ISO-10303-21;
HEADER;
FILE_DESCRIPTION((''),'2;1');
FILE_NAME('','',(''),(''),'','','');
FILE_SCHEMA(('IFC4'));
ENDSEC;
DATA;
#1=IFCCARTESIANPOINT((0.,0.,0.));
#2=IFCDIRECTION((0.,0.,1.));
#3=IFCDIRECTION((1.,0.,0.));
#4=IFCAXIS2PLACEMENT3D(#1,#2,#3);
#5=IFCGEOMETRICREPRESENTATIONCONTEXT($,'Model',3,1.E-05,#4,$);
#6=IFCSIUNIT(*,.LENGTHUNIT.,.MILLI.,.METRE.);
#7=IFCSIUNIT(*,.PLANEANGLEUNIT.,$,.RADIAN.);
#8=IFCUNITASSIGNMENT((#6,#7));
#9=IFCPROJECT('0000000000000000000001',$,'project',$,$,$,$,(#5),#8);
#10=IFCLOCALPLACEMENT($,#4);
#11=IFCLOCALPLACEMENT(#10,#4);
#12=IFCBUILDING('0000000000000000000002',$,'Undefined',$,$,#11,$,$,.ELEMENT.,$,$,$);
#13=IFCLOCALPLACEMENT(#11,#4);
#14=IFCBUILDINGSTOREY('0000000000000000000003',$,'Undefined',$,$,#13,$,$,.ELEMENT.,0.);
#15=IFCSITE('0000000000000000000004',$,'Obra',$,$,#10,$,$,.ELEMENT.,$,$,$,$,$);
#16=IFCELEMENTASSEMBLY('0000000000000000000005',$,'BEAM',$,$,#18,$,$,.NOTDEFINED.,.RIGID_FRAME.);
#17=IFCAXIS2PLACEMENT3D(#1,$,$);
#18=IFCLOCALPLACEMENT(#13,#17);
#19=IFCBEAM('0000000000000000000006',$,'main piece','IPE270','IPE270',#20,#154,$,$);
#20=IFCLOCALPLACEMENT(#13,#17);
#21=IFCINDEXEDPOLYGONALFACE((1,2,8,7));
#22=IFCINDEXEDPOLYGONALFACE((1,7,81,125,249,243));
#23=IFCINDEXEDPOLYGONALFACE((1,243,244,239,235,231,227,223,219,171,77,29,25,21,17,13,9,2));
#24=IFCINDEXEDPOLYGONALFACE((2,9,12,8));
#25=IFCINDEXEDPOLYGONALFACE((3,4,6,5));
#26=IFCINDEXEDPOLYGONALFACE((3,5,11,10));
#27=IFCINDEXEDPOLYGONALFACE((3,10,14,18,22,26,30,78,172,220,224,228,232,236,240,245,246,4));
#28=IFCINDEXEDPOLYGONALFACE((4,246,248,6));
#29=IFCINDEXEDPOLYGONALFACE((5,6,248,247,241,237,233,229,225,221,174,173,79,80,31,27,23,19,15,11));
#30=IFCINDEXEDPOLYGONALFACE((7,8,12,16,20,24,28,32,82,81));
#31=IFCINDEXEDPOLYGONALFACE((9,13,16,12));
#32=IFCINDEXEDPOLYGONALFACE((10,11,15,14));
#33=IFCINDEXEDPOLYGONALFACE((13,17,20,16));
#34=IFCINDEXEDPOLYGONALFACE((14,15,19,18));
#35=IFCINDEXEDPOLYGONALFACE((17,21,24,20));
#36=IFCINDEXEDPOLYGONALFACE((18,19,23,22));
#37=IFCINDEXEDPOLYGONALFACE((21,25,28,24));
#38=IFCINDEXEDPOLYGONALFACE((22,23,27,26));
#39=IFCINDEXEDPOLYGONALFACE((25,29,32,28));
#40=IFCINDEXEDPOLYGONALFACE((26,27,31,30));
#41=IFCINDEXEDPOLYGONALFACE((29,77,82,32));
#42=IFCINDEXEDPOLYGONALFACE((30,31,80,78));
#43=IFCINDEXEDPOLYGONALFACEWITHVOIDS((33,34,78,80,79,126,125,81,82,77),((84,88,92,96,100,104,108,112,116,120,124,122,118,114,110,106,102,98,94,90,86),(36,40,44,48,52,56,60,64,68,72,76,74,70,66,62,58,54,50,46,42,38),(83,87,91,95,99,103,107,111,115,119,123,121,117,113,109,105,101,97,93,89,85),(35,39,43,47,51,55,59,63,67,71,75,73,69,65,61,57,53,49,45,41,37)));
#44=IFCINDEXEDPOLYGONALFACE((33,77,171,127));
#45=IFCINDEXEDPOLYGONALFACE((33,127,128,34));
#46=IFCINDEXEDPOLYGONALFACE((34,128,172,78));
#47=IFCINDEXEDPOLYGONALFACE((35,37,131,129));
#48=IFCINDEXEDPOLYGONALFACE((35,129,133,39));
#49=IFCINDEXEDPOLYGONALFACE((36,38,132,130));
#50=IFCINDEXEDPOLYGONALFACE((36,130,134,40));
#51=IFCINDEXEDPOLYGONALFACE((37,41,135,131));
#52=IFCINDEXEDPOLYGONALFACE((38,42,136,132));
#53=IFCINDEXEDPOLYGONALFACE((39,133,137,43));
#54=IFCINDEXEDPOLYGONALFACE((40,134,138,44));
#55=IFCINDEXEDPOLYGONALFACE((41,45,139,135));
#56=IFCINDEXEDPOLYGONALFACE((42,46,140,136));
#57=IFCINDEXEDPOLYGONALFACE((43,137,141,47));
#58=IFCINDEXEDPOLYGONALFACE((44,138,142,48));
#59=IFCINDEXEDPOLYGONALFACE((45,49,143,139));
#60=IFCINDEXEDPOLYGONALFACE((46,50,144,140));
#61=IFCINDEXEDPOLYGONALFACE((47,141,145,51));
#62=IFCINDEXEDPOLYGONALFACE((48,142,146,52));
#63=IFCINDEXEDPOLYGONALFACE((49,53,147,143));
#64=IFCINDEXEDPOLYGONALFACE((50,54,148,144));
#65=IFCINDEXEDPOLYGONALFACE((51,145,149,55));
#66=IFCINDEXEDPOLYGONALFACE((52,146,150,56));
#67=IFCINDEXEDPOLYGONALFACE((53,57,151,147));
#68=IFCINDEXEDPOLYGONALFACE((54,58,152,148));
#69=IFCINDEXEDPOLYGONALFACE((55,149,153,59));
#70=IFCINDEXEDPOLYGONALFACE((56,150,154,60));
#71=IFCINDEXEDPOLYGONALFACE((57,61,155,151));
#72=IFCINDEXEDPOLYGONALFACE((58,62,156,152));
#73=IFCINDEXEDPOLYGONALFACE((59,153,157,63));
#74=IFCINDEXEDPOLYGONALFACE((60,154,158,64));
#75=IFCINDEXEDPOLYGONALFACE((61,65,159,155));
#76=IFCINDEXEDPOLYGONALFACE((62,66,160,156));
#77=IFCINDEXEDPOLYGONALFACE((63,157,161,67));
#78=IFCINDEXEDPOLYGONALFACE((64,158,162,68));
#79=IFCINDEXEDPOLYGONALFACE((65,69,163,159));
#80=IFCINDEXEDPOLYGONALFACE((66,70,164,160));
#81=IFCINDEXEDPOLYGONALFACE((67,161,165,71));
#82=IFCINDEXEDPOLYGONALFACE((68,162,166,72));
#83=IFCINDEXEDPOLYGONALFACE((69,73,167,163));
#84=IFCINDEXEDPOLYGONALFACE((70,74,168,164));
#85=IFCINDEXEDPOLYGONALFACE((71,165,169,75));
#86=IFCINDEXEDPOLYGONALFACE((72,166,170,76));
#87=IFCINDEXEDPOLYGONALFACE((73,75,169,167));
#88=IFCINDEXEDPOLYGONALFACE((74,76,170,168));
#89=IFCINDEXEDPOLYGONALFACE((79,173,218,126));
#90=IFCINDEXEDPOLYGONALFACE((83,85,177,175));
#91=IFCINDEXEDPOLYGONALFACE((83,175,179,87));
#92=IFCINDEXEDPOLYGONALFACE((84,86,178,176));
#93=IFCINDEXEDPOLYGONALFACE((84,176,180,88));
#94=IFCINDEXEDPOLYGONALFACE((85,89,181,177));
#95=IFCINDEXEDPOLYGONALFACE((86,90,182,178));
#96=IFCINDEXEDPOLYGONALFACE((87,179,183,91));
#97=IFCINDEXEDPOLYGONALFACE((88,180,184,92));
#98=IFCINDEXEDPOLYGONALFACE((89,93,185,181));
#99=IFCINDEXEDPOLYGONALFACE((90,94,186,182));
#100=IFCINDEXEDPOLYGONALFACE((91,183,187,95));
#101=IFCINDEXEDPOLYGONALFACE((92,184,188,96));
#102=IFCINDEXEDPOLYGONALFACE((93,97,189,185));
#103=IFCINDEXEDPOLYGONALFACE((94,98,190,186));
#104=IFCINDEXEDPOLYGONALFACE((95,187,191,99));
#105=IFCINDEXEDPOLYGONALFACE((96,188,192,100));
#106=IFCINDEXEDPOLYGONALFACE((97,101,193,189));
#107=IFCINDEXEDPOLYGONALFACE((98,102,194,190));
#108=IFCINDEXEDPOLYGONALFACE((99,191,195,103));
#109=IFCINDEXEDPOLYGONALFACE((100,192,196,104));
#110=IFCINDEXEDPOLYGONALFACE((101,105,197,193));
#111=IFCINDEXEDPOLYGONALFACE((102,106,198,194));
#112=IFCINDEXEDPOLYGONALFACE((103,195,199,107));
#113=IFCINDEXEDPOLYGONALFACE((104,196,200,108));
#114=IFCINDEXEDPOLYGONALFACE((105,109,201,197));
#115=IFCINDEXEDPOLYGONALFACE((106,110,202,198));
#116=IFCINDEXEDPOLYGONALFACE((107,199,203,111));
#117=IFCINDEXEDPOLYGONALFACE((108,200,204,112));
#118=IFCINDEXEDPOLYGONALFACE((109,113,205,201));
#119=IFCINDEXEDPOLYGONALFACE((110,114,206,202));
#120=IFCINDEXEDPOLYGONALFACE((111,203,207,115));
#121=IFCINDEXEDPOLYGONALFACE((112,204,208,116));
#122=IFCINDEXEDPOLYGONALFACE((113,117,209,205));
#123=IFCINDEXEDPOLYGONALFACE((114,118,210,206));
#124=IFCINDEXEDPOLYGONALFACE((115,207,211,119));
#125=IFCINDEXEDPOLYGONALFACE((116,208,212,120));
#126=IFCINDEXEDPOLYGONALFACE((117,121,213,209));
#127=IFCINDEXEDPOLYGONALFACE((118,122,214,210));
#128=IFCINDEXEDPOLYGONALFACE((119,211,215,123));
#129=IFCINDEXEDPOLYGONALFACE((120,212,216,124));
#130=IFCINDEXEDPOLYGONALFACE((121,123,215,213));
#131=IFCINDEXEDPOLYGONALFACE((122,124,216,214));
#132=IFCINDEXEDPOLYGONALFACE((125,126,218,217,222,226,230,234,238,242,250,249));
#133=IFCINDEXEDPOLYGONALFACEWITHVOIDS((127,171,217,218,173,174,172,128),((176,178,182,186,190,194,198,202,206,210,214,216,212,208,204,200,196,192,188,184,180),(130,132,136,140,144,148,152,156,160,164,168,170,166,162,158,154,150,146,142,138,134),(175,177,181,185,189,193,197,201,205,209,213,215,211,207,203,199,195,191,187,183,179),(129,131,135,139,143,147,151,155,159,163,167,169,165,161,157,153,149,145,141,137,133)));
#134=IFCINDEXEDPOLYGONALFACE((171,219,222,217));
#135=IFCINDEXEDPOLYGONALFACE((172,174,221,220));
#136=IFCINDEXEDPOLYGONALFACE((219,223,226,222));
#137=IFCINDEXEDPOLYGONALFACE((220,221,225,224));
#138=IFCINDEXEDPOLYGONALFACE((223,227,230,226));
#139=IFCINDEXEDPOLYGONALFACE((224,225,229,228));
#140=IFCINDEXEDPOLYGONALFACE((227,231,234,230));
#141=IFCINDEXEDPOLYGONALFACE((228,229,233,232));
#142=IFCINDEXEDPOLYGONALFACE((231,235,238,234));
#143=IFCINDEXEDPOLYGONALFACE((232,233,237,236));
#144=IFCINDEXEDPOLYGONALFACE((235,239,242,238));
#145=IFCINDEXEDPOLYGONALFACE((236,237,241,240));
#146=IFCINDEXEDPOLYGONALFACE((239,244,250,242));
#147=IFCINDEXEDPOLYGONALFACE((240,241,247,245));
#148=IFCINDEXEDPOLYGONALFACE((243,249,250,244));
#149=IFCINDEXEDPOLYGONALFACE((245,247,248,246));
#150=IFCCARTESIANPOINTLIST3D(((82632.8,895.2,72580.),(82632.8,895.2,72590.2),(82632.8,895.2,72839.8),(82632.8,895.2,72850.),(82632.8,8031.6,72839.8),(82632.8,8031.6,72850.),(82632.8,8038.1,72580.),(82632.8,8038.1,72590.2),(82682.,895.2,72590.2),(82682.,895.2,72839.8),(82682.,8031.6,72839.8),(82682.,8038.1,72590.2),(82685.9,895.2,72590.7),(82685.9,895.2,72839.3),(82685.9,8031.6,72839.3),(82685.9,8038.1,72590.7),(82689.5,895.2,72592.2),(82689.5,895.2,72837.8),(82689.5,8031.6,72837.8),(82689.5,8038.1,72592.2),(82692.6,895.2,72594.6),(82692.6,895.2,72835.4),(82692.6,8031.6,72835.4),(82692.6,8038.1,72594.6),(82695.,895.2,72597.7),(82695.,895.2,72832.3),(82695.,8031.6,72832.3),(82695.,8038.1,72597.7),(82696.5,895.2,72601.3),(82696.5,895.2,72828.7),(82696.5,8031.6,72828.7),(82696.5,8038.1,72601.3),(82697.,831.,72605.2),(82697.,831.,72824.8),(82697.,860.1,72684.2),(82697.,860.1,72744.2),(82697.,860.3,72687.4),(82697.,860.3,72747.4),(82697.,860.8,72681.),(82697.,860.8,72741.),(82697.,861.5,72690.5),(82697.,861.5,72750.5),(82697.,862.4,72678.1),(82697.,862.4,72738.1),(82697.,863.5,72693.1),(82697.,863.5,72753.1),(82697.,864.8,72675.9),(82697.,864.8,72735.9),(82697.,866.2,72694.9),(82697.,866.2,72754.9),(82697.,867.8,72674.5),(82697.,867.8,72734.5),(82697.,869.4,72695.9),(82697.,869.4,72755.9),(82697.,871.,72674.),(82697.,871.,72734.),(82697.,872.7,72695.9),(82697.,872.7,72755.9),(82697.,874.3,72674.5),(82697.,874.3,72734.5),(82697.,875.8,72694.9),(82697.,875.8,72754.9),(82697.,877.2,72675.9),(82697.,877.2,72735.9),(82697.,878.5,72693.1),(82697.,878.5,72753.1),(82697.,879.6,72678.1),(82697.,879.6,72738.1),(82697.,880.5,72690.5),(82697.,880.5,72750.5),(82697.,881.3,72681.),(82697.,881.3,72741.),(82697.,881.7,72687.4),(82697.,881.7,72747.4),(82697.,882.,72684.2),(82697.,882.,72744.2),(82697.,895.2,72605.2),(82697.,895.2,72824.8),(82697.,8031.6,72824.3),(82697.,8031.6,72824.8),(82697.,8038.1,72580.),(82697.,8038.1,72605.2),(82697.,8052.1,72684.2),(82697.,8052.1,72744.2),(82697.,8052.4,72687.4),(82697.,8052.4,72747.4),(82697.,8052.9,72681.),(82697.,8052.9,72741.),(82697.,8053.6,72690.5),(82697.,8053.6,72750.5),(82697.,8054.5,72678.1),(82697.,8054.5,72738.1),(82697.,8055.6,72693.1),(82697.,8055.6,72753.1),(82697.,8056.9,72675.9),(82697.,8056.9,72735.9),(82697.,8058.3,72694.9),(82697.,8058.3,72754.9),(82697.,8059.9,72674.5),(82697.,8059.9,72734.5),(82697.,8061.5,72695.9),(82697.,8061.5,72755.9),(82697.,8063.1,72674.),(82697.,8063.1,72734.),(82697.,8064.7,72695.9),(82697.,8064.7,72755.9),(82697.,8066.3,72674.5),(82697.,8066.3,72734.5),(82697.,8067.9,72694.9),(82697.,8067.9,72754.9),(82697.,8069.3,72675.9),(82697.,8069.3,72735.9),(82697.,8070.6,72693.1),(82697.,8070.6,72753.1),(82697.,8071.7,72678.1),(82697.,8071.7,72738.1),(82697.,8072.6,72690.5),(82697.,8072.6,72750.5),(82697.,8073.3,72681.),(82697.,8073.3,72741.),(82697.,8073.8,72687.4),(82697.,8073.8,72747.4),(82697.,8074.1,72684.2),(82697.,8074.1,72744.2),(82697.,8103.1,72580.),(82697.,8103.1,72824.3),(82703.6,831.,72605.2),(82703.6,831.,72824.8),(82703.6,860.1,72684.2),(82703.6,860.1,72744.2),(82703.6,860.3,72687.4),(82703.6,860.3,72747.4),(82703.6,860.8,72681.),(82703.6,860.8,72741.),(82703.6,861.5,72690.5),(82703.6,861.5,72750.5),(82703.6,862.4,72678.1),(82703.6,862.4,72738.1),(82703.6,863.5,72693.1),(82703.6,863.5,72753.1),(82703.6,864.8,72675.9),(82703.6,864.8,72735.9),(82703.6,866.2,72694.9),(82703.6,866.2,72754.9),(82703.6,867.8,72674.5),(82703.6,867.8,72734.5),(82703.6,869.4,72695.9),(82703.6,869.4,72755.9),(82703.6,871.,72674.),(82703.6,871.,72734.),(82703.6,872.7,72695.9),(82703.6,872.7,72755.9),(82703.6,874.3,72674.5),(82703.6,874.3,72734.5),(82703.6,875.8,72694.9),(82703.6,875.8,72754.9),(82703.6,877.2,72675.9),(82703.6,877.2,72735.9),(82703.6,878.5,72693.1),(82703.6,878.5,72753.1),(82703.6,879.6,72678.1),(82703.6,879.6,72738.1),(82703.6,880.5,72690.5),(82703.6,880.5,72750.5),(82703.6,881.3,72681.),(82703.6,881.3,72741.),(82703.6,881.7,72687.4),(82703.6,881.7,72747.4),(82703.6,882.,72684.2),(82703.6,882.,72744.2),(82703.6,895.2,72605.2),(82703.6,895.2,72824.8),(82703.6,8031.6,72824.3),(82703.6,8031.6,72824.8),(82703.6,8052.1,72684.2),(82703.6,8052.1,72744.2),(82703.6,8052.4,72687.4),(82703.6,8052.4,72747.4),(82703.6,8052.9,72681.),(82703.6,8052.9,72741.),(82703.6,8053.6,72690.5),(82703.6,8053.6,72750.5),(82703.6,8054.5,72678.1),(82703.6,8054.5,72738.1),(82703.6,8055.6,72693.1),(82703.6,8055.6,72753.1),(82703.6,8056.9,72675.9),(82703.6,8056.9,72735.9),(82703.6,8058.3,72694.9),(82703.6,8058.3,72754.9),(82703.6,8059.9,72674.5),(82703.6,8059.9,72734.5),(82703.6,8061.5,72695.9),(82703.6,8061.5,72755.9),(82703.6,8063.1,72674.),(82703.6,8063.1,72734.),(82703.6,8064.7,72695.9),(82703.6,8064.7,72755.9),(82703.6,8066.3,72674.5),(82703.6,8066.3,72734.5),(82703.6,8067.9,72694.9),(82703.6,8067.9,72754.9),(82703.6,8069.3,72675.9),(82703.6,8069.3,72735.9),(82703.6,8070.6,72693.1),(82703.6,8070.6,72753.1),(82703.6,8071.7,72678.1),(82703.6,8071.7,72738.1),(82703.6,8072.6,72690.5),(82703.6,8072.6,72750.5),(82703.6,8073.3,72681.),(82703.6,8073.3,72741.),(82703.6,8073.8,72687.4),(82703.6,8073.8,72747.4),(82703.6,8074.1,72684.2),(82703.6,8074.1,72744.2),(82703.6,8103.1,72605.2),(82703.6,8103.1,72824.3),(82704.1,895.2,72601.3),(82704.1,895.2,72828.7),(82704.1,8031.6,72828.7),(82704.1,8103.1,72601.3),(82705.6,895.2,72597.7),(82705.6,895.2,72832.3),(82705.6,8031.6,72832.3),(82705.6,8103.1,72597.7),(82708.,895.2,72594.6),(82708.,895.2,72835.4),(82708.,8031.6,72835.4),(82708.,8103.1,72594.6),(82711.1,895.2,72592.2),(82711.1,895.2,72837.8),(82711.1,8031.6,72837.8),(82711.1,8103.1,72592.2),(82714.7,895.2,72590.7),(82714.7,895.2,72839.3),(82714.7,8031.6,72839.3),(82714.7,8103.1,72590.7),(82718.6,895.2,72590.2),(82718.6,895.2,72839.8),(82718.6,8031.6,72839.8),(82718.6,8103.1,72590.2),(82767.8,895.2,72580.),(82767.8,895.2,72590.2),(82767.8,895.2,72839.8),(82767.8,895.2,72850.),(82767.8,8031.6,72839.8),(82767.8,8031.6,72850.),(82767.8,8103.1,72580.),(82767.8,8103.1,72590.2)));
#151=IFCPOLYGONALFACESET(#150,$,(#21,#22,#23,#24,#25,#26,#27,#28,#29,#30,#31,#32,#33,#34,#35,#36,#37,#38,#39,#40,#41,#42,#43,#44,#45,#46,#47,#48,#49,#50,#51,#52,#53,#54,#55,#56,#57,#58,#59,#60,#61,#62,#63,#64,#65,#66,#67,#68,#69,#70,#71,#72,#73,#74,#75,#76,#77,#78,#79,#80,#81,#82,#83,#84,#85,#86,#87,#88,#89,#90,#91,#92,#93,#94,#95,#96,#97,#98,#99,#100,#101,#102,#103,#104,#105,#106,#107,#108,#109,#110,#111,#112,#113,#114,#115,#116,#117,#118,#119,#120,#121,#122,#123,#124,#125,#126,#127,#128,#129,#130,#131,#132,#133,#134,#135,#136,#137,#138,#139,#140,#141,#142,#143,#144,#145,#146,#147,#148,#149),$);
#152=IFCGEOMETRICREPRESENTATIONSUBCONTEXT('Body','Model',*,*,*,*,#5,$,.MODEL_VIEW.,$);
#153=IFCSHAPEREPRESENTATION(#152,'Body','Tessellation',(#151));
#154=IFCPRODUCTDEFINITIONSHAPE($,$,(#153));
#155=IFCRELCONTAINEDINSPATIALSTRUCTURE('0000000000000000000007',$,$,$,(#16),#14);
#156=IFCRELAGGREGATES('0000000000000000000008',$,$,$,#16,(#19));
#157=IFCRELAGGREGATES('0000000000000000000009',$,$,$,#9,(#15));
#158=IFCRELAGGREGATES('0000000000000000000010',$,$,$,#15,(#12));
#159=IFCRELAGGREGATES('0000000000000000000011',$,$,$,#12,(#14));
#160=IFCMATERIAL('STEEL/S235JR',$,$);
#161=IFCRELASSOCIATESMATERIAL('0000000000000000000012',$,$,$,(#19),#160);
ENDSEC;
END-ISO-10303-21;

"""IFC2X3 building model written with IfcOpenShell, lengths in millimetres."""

from ifc_helpers import new_model, si_unit, frame, origin_with_axes, origin_2d_with_axis, place, context, subcontext, project, spatial, rectangle, circle, i_section, extrude, clip, halfspace, source, transform, mapped, material, element, aggregate, save


model = new_model("IFC2X3")

# Units and contexts
model_context = context("Model", 3, precision=1e-05, world=origin_with_axes())
body_context = subcontext(model_context, "Body", "Model", "MODEL_VIEW")
ifc_project = project(units=[si_unit("LENGTHUNIT", "METRE", prefix="MILLI"), si_unit("PLANEANGLEUNIT", "RADIAN")], contexts=[model_context])

# Site, building, storey
site_placement = place(None, origin_with_axes())
site = spatial("IfcSite", under=ifc_project, at=site_placement, Name="Obra", CompositionType="ELEMENT")
building_placement = place(site_placement, origin_with_axes())
building = spatial("IfcBuilding", under=site, at=building_placement, Name="Undefined", CompositionType="ELEMENT")
storey_placement = place(building_placement, origin_with_axes())
storey = spatial("IfcBuildingStorey", under=building, at=storey_placement, Name="Undefined", CompositionType="ELEMENT", Elevation=0.0)

# Shared definitions
ifc_material = material(Name="STEEL/S235JR")

# Element assembly, beam, openings
shared_shape = source(origin_with_axes(), body_context, "Body", "SweptSolid", [
    extrude(circle(Radius=11.0, at=origin_2d_with_axis()), frame((0.0, -3.4, 0.0), z_axis=(0.0, 1.0, 0.0), x_axis=(1.0, 0.0, 0.0)), (0.0, 0.0, 1.0), 6.8),
])
assembly_1_placement = place(storey_placement, origin_with_axes())
assembly_1 = element("IfcElementAssembly", 1, at=assembly_1_placement, inside=storey, Name="BEAM", AssemblyPlace="NOTDEFINED", PredefinedType="RIGID_FRAME")
beam_1_placement = place(assembly_1_placement, frame((82700.3, 898.0, 72715.0), z_axis=(0.0, 0.0, 1.0), x_axis=(0.0, 1.0, 0.0)))
beam_1 = element("IfcBeam", 2, at=beam_1_placement, material=ifc_material, Name="main piece", Description="IPE270", ObjectType="IPE270", context=body_context, shape_type="Clipping", body=[
    clip(clip(extrude(i_section(OverallWidth=135.0, OverallDepth=270.0, WebThickness=6.6, FlangeThickness=10.2, FilletRadius=15.0, at=origin_2d_with_axis()), frame((7205.1, 0.0, 0.0), z_axis=(-1.0, 0.0, 0.0), x_axis=(0.0, -1.0, 0.0)), (0.0, 0.0, 1.0), 7272.1), halfspace(frame((7205.1, 0.0, -235.0), z_axis=(-1.0, 0.0, 0.0), x_axis=(0.0, 1.0, 0.0)), True)), halfspace(frame((-66.9, 0.0, -235.0), z_axis=(1.0, 0.0, 0.0), x_axis=(0.0, -1.0, 0.0)), True)),
])
opening_1_placement = place(assembly_1_placement, frame((82700.3, 898.0, 72715.0), z_axis=(0.0, 0.0, 1.0), x_axis=(0.0, 1.0, 0.0)))
element("IfcOpeningElement", 3, at=opening_1_placement, cuts=beam_1, ObjectType="Recess", context=body_context, shape_type="SweptSolid", body=[
    extrude(rectangle(XDim=75.0, YDim=300.0, at=origin_2d_with_axis()), frame((7177.6, 153.3, 124.3), z_axis=(0.0, 0.0, -1.0), x_axis=(-1.0, 0.0, 0.0)), (0.0, 0.0, 1.0), 278.6),
])
opening_2_placement = place(assembly_1_placement, frame((82700.3, 898.0, 72715.0), z_axis=(0.0, 0.0, 1.0), x_axis=(0.0, 1.0, 0.0)))
element("IfcOpeningElement", 4, at=opening_2_placement, cuts=beam_1, ObjectType="Recess", context=body_context, shape_type="SweptSolid", body=[
    extrude(rectangle(XDim=26.7, YDim=83.5, at=origin_2d_with_axis()), frame((7175.4, 68.5, 122.7), z_axis=(0.0, -1.0, 0.0), x_axis=(0.0, 0.0, -1.0)), (0.0, 0.0, 1.0), 137.0),
])
opening_3_placement = place(assembly_1_placement, frame((82700.3, 898.0, 72715.0), z_axis=(0.0, 0.0, 1.0), x_axis=(0.0, 1.0, 0.0)))
element("IfcOpeningElement", 5, at=opening_3_placement, cuts=beam_1, ObjectType="Recess", context=body_context, shape_type="SweptSolid", body=[
    extrude(rectangle(XDim=26.2, YDim=76.2, at=origin_2d_with_axis()), frame((-40.8, -68.5, -122.9), z_axis=(0.0, 1.0, 0.0), x_axis=(0.0, 0.0, -1.0)), (0.0, 0.0, 1.0), 137.0),
])
opening_4_placement = place(assembly_1_placement, frame((82700.3, 898.0, 72715.0), z_axis=(0.0, 0.0, 1.0), x_axis=(0.0, 1.0, 0.0)))
element("IfcOpeningElement", 6, at=opening_4_placement, cuts=beam_1, ObjectType="Recess", context=body_context, shape_type="SweptSolid", body=[
    extrude(rectangle(XDim=26.2, YDim=76.2, at=origin_2d_with_axis()), frame((-40.8, -68.5, 122.9), z_axis=(0.0, 1.0, 0.0), x_axis=(0.0, 0.0, -1.0)), (0.0, 0.0, 1.0), 137.0),
])
opening_5_placement = place(assembly_1_placement, frame((82700.3, 8103.1, 72850.0), z_axis=(0.0, -1.0, 0.0), x_axis=(0.0, 0.0, -1.0)))
element("IfcOpeningElement", 7, at=opening_5_placement, cuts=beam_1, ObjectType="Opening", context=body_context, shape_type="MappedRepresentation", body=[
    mapped(shared_shape, transform((105.0, 0.0, 40.0))),
    mapped(shared_shape, transform((165.0, 0.0, 40.0))),
])
opening_6_placement = place(assembly_1_placement, frame((82700.3, 831.0, 72850.0), z_axis=(0.0, 1.0, 0.0), x_axis=(0.0, 0.0, -1.0)))
element("IfcOpeningElement", 8, at=opening_6_placement, cuts=beam_1, ObjectType="Opening", context=body_context, shape_type="MappedRepresentation", body=[
    mapped(shared_shape, transform((105.0, 0.0, 40.0))),
    mapped(shared_shape, transform((165.0, 0.0, 40.0))),
])
aggregate(assembly_1, [beam_1])

save(model, "model.ifc")
